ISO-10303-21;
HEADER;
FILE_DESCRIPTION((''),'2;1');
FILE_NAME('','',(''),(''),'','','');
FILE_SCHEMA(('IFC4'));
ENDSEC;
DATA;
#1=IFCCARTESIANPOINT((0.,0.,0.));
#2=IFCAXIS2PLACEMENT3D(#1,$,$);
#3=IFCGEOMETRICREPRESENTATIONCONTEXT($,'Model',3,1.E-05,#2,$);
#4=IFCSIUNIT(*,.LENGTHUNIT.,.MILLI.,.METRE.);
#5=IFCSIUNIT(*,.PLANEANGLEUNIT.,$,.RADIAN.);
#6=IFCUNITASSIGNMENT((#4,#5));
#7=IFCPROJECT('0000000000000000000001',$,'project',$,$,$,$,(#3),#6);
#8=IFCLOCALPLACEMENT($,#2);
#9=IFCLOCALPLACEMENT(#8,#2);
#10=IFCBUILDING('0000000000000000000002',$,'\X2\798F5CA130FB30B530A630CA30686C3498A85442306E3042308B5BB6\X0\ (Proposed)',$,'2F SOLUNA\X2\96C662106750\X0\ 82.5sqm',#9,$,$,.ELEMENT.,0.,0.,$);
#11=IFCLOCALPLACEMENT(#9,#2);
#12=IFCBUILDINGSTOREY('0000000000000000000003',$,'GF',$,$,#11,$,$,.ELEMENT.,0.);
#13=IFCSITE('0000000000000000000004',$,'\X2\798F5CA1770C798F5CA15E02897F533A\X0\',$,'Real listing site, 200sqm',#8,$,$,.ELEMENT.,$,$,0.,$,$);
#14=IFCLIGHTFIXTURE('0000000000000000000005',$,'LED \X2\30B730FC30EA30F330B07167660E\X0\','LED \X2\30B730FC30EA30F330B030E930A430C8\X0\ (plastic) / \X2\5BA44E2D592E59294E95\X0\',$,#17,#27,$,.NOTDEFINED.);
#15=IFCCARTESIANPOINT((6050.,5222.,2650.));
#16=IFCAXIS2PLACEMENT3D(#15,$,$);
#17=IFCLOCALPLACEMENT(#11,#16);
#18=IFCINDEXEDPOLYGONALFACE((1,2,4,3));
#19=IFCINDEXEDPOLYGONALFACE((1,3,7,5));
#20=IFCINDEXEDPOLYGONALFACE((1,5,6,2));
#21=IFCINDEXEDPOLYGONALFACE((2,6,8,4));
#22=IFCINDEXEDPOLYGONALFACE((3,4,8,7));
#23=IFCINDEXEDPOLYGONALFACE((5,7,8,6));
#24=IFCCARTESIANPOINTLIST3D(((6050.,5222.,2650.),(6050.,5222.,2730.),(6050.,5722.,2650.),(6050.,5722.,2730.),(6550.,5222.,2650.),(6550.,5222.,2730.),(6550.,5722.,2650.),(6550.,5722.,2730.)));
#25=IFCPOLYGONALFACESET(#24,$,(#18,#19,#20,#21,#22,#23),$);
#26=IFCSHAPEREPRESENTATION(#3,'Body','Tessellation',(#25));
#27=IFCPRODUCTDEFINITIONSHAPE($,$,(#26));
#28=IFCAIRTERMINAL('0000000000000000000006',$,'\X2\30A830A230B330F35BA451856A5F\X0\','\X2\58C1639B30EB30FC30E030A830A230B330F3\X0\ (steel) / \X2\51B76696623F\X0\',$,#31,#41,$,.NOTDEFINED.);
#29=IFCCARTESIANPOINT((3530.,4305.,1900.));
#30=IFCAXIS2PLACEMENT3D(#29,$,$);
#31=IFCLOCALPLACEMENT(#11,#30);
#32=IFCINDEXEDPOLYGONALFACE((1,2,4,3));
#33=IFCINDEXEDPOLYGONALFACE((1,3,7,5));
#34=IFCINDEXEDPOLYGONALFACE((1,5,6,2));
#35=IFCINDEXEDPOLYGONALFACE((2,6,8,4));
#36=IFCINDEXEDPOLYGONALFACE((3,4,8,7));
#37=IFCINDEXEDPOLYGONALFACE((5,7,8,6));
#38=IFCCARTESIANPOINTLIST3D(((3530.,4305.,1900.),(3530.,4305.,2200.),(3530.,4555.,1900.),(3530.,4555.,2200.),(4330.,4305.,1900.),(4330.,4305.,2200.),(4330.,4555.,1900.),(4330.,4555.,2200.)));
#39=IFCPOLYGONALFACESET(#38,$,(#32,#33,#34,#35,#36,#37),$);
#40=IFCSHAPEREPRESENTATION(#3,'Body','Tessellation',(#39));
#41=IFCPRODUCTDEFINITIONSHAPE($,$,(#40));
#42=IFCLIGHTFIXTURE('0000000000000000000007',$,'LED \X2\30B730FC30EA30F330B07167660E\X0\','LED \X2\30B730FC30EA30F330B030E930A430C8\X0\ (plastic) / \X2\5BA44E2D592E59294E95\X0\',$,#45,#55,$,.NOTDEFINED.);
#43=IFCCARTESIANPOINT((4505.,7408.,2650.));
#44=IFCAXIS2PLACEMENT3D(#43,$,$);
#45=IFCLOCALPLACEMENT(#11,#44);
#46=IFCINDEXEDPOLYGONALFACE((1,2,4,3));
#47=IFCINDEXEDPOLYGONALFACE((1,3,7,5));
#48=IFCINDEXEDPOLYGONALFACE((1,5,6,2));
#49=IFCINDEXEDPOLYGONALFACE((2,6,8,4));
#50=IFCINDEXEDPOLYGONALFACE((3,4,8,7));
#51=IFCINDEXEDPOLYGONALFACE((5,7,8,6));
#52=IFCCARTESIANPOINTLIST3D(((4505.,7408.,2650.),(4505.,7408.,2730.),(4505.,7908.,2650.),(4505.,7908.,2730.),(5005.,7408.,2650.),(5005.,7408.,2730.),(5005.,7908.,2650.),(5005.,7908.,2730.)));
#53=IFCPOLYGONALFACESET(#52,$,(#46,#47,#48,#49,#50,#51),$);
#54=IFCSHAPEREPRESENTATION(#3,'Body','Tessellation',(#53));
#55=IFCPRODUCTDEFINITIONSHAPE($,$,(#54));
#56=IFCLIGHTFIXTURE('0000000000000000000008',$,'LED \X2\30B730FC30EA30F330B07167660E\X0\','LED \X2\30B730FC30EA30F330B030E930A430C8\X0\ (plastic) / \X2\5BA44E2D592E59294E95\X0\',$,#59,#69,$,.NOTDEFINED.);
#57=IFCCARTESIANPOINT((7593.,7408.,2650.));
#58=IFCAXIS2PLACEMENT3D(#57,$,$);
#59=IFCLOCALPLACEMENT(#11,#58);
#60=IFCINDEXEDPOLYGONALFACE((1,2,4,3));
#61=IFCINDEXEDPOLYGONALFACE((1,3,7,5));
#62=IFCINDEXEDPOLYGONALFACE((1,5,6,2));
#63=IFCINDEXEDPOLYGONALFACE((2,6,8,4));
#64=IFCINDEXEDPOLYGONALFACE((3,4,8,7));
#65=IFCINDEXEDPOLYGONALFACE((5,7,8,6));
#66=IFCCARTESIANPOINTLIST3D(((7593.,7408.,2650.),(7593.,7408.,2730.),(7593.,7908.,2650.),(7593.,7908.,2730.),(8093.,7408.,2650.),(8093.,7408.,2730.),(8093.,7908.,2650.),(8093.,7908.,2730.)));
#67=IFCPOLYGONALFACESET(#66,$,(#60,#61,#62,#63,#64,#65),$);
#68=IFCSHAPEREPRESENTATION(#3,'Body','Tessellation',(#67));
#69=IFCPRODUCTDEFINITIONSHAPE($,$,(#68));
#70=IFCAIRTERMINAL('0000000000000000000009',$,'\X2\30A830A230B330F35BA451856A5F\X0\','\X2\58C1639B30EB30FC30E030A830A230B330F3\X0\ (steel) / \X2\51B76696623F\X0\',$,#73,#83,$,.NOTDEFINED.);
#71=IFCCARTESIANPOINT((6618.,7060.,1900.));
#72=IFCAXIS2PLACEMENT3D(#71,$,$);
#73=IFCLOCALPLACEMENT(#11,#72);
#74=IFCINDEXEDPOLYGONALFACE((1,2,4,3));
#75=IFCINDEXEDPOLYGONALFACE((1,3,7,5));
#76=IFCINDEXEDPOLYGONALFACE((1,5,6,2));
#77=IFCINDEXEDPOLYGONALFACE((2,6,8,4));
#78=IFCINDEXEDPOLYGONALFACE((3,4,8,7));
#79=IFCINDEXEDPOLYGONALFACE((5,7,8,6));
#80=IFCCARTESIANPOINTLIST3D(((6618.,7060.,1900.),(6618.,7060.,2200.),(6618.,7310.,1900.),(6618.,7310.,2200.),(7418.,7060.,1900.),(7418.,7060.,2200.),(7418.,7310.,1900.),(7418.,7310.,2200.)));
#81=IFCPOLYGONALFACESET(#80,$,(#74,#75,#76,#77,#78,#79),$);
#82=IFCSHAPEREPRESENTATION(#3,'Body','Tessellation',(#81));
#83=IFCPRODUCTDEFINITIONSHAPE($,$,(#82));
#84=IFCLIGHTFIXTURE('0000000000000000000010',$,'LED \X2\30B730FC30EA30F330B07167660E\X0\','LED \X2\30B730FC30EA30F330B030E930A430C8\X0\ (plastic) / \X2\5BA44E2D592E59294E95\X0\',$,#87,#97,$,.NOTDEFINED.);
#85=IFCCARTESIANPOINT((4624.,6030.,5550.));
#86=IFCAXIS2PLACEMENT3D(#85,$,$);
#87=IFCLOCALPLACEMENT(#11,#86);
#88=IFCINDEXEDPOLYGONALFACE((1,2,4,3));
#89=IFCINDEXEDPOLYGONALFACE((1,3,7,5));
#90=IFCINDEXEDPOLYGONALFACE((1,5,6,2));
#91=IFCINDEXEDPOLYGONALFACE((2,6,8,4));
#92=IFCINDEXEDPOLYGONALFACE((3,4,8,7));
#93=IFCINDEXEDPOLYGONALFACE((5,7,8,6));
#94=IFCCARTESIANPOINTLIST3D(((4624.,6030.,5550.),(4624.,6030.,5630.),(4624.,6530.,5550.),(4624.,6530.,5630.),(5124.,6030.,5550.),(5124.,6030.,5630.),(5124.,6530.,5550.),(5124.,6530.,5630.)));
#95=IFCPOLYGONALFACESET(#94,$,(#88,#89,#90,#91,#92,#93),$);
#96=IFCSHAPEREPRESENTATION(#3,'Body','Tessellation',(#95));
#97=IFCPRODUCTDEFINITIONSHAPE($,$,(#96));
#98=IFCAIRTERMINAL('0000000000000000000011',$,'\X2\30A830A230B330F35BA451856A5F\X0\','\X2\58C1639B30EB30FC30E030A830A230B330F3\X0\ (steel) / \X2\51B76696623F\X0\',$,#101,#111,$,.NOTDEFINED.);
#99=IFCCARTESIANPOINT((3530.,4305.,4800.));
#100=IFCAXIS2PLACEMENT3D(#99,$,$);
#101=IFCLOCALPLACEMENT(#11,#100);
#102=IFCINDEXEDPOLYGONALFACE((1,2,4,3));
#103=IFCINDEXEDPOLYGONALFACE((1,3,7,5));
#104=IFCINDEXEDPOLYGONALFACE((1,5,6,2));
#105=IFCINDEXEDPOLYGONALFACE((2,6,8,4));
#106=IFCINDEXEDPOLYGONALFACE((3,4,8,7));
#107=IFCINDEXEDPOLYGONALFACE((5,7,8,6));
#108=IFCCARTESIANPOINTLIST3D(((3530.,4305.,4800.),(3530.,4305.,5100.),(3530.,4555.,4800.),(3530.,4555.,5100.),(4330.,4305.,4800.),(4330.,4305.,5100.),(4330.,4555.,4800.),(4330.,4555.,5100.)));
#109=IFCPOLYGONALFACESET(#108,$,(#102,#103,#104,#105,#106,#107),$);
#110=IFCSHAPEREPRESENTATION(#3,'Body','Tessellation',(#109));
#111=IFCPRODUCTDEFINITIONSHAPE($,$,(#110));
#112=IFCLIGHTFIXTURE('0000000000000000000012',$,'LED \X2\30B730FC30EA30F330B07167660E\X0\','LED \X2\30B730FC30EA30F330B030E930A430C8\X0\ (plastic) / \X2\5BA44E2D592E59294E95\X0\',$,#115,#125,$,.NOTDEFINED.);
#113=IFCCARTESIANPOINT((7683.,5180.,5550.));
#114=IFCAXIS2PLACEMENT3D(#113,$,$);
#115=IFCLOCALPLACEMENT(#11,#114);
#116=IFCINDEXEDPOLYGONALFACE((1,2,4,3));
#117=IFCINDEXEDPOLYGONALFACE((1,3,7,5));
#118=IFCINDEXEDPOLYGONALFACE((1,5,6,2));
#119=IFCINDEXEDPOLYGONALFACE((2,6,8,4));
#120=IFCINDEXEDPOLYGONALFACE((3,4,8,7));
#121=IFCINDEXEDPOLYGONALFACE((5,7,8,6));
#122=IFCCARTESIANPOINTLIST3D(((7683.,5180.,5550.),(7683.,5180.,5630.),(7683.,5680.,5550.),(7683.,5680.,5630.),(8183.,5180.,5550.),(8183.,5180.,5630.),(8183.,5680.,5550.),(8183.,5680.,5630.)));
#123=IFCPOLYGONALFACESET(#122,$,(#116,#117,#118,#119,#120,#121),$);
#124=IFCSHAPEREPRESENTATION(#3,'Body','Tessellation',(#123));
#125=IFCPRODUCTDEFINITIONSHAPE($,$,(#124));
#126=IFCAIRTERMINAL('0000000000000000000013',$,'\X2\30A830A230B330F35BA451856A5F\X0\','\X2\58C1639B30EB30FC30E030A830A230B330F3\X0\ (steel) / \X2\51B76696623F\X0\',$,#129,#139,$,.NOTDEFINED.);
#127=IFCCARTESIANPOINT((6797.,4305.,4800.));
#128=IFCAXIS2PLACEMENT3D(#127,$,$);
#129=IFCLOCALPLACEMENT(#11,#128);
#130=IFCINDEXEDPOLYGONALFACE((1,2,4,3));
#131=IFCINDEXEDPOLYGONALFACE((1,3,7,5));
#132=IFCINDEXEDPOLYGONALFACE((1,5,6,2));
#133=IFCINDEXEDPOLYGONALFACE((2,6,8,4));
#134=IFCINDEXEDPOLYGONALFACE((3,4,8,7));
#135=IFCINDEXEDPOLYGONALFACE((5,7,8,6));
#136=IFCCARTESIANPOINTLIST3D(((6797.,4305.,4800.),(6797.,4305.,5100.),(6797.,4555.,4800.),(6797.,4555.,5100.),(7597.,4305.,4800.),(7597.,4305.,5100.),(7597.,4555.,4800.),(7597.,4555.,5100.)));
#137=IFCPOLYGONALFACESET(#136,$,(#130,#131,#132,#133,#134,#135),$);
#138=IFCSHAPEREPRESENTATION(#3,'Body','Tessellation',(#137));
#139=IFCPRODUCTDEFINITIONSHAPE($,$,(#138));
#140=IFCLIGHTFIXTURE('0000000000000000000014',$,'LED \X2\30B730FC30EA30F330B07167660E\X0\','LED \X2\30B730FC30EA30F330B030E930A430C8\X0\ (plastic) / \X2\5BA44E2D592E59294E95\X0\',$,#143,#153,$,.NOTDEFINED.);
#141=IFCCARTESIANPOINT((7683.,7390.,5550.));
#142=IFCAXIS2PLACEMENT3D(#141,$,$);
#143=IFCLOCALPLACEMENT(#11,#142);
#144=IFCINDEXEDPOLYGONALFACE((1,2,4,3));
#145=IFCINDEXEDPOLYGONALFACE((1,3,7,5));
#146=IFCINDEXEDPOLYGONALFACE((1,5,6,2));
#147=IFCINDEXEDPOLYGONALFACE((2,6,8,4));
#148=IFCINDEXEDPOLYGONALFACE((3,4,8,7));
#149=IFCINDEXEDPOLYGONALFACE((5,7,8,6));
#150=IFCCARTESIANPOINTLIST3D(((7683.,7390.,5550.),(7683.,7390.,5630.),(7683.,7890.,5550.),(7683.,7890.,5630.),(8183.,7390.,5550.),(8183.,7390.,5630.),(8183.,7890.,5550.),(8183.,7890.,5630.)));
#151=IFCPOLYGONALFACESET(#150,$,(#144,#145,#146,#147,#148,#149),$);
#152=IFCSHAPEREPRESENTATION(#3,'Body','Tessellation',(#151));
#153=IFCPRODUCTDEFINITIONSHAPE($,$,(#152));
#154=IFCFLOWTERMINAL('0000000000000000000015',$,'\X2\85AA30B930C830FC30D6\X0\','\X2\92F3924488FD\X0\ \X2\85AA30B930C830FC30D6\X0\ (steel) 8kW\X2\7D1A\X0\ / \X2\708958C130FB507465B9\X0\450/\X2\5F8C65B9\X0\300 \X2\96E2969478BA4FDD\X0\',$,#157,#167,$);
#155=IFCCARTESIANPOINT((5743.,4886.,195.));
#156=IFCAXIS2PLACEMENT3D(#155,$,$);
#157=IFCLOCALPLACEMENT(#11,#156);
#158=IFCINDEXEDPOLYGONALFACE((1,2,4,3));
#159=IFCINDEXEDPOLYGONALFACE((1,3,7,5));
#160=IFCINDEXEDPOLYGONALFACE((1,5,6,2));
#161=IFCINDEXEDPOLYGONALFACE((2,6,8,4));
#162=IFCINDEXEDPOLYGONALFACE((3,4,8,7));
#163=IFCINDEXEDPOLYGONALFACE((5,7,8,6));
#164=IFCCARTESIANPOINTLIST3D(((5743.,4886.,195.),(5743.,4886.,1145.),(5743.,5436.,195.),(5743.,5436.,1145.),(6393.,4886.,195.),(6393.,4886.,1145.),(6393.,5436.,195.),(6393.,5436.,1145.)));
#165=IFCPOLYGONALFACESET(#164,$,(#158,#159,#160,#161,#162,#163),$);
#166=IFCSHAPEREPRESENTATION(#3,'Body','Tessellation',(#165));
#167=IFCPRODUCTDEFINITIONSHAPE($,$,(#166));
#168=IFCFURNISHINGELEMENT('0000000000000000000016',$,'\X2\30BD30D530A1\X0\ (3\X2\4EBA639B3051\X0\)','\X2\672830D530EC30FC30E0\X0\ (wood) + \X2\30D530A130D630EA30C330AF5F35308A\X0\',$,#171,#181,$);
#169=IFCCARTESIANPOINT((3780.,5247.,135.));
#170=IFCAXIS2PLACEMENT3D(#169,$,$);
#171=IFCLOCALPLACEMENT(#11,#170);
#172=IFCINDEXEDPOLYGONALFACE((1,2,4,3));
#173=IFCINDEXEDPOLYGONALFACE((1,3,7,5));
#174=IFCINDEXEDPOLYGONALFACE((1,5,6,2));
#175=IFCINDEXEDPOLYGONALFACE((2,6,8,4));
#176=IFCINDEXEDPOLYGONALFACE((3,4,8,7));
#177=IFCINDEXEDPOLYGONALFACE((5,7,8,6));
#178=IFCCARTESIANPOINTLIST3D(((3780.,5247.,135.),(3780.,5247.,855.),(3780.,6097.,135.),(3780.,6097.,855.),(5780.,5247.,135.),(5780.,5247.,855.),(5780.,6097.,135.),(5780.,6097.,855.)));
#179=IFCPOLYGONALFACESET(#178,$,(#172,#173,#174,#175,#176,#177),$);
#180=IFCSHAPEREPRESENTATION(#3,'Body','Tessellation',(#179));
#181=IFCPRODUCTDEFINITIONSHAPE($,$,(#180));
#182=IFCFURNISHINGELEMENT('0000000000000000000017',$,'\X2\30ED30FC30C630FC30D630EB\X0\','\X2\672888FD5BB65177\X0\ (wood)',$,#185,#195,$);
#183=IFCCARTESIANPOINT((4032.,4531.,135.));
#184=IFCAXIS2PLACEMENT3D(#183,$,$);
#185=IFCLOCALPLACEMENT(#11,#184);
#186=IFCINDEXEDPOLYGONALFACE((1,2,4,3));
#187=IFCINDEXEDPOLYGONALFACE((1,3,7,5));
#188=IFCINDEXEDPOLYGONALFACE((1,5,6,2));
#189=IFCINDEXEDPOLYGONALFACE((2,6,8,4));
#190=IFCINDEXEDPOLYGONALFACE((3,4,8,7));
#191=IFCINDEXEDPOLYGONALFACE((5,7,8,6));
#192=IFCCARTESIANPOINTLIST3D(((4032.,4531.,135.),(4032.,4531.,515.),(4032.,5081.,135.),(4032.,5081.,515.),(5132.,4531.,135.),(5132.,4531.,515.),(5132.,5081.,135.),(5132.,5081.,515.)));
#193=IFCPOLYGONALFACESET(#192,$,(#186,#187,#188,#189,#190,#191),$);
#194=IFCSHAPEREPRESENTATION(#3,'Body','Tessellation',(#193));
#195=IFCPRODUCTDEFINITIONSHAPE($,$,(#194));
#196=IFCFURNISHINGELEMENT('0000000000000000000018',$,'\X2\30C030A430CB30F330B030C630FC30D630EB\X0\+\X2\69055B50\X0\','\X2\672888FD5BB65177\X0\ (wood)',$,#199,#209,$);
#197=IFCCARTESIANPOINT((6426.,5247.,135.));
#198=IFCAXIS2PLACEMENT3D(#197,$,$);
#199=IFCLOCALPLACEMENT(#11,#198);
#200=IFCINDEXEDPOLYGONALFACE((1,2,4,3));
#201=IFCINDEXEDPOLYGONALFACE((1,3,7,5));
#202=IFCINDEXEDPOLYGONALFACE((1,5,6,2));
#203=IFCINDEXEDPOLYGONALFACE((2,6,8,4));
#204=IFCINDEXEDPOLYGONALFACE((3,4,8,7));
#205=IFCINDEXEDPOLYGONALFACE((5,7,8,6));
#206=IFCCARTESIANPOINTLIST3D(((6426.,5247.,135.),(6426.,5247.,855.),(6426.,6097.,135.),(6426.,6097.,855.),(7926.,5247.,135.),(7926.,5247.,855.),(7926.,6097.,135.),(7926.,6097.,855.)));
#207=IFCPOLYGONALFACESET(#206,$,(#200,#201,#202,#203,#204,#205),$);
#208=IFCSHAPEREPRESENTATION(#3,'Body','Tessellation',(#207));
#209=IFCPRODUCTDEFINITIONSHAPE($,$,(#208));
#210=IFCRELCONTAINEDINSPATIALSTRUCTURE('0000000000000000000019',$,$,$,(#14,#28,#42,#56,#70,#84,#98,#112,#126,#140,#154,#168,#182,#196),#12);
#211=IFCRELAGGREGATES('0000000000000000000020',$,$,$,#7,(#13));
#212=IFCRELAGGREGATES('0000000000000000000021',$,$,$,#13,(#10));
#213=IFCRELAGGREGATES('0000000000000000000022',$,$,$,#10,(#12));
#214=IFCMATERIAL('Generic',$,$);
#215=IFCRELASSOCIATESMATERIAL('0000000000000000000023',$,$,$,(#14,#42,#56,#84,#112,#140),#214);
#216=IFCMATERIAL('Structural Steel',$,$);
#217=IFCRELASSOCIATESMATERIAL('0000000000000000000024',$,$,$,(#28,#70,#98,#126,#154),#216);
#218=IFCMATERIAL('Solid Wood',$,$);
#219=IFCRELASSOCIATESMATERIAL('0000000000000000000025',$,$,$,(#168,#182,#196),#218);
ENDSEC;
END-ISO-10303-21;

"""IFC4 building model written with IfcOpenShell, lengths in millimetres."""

from ifc_helpers import new_model, si_unit, frame, frame_2d, origin, place, context, project, spatial, rectangle, extrude, material, element, save


model = new_model("IFC4")

# Units and contexts
model_context = context("Model", 3, precision=1e-05, world=origin())
ifc_project = project(units=[si_unit("LENGTHUNIT", "METRE", prefix="MILLI"), si_unit("PLANEANGLEUNIT", "RADIAN")], contexts=[model_context])

# Site, building, storey
site_placement = place(None, origin())
site = spatial("IfcSite", under=ifc_project, at=site_placement, Name="福岡県福岡市西区", ObjectType="Real listing site, 200sqm", CompositionType="ELEMENT", RefElevation=0.0)
building_placement = place(site_placement, origin())
building = spatial("IfcBuilding", under=site, at=building_placement, Name="福岡・サウナと水風呂のある家 (Proposed)", ObjectType="2F SOLUNA集成材 82.5sqm", CompositionType="ELEMENT", ElevationOfRefHeight=0.0, ElevationOfTerrain=0.0)
storey_placement = place(building_placement, origin())
storey = spatial("IfcBuildingStorey", under=building, at=storey_placement, Name="GF", CompositionType="ELEMENT", Elevation=0.0)

# Shared definitions
ifc_material_1 = material(Name="Solid Wood")

# Shared definitions
ifc_material_2 = material(Name="Structural Steel")

# Shared definitions
ifc_material_3 = material(Name="Generic")

# Light fixture
light_fixture_1_placement = place(storey_placement, frame((6050.0, 5222.0, 2650.0)))
element("IfcLightFixture", 1, at=light_fixture_1_placement, inside=storey, material=ifc_material_3, Name="LED シーリング照明", Description="LED シーリングライト (plastic) / 室中央天井", PredefinedType="NOTDEFINED", context=model_context, shape_type="SweptSolid", body=[
    extrude(rectangle(XDim=500.0, YDim=500.0, at=frame_2d((250.0, 250.0))), frame((6050.0, 5222.0, 2650.0)), (0.0, 0.0, 1.0), 80.0),
])

# Air terminal
air_terminal_1_placement = place(storey_placement, frame((3530.0, 4305.0, 1900.0)))
element("IfcAirTerminal", 2, at=air_terminal_1_placement, inside=storey, material=ifc_material_2, Name="エアコン室内機", Description="壁掛ルームエアコン (steel) / 冷暖房", PredefinedType="NOTDEFINED", context=model_context, shape_type="SweptSolid", body=[
    extrude(rectangle(XDim=800.0, YDim=250.0, at=frame_2d((400.0, 125.0))), frame((3530.0, 4305.0, 1900.0)), (0.0, 0.0, 1.0), 300.0),
])

# Light fixtures
light_fixture_2_placement = place(storey_placement, frame((4505.0, 7408.0, 2650.0)))
element("IfcLightFixture", 3, at=light_fixture_2_placement, inside=storey, material=ifc_material_3, Name="LED シーリング照明", Description="LED シーリングライト (plastic) / 室中央天井", PredefinedType="NOTDEFINED", context=model_context, shape_type="SweptSolid", body=[
    extrude(rectangle(XDim=500.0, YDim=500.0, at=frame_2d((250.0, 250.0))), frame((4505.0, 7408.0, 2650.0)), (0.0, 0.0, 1.0), 80.0),
])
light_fixture_3_placement = place(storey_placement, frame((7593.0, 7408.0, 2650.0)))
element("IfcLightFixture", 4, at=light_fixture_3_placement, inside=storey, material=ifc_material_3, Name="LED シーリング照明", Description="LED シーリングライト (plastic) / 室中央天井", PredefinedType="NOTDEFINED", context=model_context, shape_type="SweptSolid", body=[
    extrude(rectangle(XDim=500.0, YDim=500.0, at=frame_2d((250.0, 250.0))), frame((7593.0, 7408.0, 2650.0)), (0.0, 0.0, 1.0), 80.0),
])

# Air terminal
air_terminal_2_placement = place(storey_placement, frame((6618.0, 7060.0, 1900.0)))
element("IfcAirTerminal", 5, at=air_terminal_2_placement, inside=storey, material=ifc_material_2, Name="エアコン室内機", Description="壁掛ルームエアコン (steel) / 冷暖房", PredefinedType="NOTDEFINED", context=model_context, shape_type="SweptSolid", body=[
    extrude(rectangle(XDim=800.0, YDim=250.0, at=frame_2d((400.0, 125.0))), frame((6618.0, 7060.0, 1900.0)), (0.0, 0.0, 1.0), 300.0),
])

# Light fixture
light_fixture_4_placement = place(storey_placement, frame((4624.0, 6030.0, 5550.0)))
element("IfcLightFixture", 6, at=light_fixture_4_placement, inside=storey, material=ifc_material_3, Name="LED シーリング照明", Description="LED シーリングライト (plastic) / 室中央天井", PredefinedType="NOTDEFINED", context=model_context, shape_type="SweptSolid", body=[
    extrude(rectangle(XDim=500.0, YDim=500.0, at=frame_2d((250.0, 250.0))), frame((4624.0, 6030.0, 5550.0)), (0.0, 0.0, 1.0), 80.0),
])

# Air terminal
air_terminal_3_placement = place(storey_placement, frame((3530.0, 4305.0, 4800.0)))
element("IfcAirTerminal", 7, at=air_terminal_3_placement, inside=storey, material=ifc_material_2, Name="エアコン室内機", Description="壁掛ルームエアコン (steel) / 冷暖房", PredefinedType="NOTDEFINED", context=model_context, shape_type="SweptSolid", body=[
    extrude(rectangle(XDim=800.0, YDim=250.0, at=frame_2d((400.0, 125.0))), frame((3530.0, 4305.0, 4800.0)), (0.0, 0.0, 1.0), 300.0),
])

# Light fixture
light_fixture_5_placement = place(storey_placement, frame((7683.0, 5180.0, 5550.0)))
element("IfcLightFixture", 8, at=light_fixture_5_placement, inside=storey, material=ifc_material_3, Name="LED シーリング照明", Description="LED シーリングライト (plastic) / 室中央天井", PredefinedType="NOTDEFINED", context=model_context, shape_type="SweptSolid", body=[
    extrude(rectangle(XDim=500.0, YDim=500.0, at=frame_2d((250.0, 250.0))), frame((7683.0, 5180.0, 5550.0)), (0.0, 0.0, 1.0), 80.0),
])

# Air terminal
air_terminal_4_placement = place(storey_placement, frame((6797.0, 4305.0, 4800.0)))
element("IfcAirTerminal", 9, at=air_terminal_4_placement, inside=storey, material=ifc_material_2, Name="エアコン室内機", Description="壁掛ルームエアコン (steel) / 冷暖房", PredefinedType="NOTDEFINED", context=model_context, shape_type="SweptSolid", body=[
    extrude(rectangle(XDim=800.0, YDim=250.0, at=frame_2d((400.0, 125.0))), frame((6797.0, 4305.0, 4800.0)), (0.0, 0.0, 1.0), 300.0),
])

# Light fixture
light_fixture_6_placement = place(storey_placement, frame((7683.0, 7390.0, 5550.0)))
element("IfcLightFixture", 10, at=light_fixture_6_placement, inside=storey, material=ifc_material_3, Name="LED シーリング照明", Description="LED シーリングライト (plastic) / 室中央天井", PredefinedType="NOTDEFINED", context=model_context, shape_type="SweptSolid", body=[
    extrude(rectangle(XDim=500.0, YDim=500.0, at=frame_2d((250.0, 250.0))), frame((7683.0, 7390.0, 5550.0)), (0.0, 0.0, 1.0), 80.0),
])

# Flow terminal
flow_terminal_1_placement = place(storey_placement, frame((5743.0, 4886.0, 195.0)))
element("IfcFlowTerminal", 11, at=flow_terminal_1_placement, inside=storey, material=ifc_material_2, Name="薪ストーブ", Description="鋳鉄製 薪ストーブ (steel) 8kW級 / 炉壁・側方450/後方300 離隔確保", context=model_context, shape_type="SweptSolid", body=[
    extrude(rectangle(XDim=650.0, YDim=550.0, at=frame_2d((325.0, 275.0))), frame((5743.0, 4886.0, 195.0)), (0.0, 0.0, 1.0), 950.0),
])

# Furnishing elements
furnishing_1_placement = place(storey_placement, frame((3780.0, 5247.0, 135.0)))
element("IfcFurnishingElement", 12, at=furnishing_1_placement, inside=storey, material=ifc_material_1, Name="ソファ (3人掛け)", Description="木フレーム (wood) + ファブリック張り", context=model_context, shape_type="SweptSolid", body=[
    extrude(rectangle(XDim=2000.0, YDim=850.0, at=frame_2d((1000.0, 425.0))), frame((3780.0, 5247.0, 135.0)), (0.0, 0.0, 1.0), 720.0),
])
furnishing_2_placement = place(storey_placement, frame((4032.0, 4531.0, 135.0)))
element("IfcFurnishingElement", 13, at=furnishing_2_placement, inside=storey, material=ifc_material_1, Name="ローテーブル", Description="木製家具 (wood)", context=model_context, shape_type="SweptSolid", body=[
    extrude(rectangle(XDim=1100.0, YDim=550.0, at=frame_2d((550.0, 275.0))), frame((4032.0, 4531.0, 135.0)), (0.0, 0.0, 1.0), 380.0),
])
furnishing_3_placement = place(storey_placement, frame((6426.0, 5247.0, 135.0)))
element("IfcFurnishingElement", 14, at=furnishing_3_placement, inside=storey, material=ifc_material_1, Name="ダイニングテーブル+椅子", Description="木製家具 (wood)", context=model_context, shape_type="SweptSolid", body=[
    extrude(rectangle(XDim=1500.0, YDim=850.0, at=frame_2d((750.0, 425.0))), frame((6426.0, 5247.0, 135.0)), (0.0, 0.0, 1.0), 720.0),
])

save(model, "model.ifc")
